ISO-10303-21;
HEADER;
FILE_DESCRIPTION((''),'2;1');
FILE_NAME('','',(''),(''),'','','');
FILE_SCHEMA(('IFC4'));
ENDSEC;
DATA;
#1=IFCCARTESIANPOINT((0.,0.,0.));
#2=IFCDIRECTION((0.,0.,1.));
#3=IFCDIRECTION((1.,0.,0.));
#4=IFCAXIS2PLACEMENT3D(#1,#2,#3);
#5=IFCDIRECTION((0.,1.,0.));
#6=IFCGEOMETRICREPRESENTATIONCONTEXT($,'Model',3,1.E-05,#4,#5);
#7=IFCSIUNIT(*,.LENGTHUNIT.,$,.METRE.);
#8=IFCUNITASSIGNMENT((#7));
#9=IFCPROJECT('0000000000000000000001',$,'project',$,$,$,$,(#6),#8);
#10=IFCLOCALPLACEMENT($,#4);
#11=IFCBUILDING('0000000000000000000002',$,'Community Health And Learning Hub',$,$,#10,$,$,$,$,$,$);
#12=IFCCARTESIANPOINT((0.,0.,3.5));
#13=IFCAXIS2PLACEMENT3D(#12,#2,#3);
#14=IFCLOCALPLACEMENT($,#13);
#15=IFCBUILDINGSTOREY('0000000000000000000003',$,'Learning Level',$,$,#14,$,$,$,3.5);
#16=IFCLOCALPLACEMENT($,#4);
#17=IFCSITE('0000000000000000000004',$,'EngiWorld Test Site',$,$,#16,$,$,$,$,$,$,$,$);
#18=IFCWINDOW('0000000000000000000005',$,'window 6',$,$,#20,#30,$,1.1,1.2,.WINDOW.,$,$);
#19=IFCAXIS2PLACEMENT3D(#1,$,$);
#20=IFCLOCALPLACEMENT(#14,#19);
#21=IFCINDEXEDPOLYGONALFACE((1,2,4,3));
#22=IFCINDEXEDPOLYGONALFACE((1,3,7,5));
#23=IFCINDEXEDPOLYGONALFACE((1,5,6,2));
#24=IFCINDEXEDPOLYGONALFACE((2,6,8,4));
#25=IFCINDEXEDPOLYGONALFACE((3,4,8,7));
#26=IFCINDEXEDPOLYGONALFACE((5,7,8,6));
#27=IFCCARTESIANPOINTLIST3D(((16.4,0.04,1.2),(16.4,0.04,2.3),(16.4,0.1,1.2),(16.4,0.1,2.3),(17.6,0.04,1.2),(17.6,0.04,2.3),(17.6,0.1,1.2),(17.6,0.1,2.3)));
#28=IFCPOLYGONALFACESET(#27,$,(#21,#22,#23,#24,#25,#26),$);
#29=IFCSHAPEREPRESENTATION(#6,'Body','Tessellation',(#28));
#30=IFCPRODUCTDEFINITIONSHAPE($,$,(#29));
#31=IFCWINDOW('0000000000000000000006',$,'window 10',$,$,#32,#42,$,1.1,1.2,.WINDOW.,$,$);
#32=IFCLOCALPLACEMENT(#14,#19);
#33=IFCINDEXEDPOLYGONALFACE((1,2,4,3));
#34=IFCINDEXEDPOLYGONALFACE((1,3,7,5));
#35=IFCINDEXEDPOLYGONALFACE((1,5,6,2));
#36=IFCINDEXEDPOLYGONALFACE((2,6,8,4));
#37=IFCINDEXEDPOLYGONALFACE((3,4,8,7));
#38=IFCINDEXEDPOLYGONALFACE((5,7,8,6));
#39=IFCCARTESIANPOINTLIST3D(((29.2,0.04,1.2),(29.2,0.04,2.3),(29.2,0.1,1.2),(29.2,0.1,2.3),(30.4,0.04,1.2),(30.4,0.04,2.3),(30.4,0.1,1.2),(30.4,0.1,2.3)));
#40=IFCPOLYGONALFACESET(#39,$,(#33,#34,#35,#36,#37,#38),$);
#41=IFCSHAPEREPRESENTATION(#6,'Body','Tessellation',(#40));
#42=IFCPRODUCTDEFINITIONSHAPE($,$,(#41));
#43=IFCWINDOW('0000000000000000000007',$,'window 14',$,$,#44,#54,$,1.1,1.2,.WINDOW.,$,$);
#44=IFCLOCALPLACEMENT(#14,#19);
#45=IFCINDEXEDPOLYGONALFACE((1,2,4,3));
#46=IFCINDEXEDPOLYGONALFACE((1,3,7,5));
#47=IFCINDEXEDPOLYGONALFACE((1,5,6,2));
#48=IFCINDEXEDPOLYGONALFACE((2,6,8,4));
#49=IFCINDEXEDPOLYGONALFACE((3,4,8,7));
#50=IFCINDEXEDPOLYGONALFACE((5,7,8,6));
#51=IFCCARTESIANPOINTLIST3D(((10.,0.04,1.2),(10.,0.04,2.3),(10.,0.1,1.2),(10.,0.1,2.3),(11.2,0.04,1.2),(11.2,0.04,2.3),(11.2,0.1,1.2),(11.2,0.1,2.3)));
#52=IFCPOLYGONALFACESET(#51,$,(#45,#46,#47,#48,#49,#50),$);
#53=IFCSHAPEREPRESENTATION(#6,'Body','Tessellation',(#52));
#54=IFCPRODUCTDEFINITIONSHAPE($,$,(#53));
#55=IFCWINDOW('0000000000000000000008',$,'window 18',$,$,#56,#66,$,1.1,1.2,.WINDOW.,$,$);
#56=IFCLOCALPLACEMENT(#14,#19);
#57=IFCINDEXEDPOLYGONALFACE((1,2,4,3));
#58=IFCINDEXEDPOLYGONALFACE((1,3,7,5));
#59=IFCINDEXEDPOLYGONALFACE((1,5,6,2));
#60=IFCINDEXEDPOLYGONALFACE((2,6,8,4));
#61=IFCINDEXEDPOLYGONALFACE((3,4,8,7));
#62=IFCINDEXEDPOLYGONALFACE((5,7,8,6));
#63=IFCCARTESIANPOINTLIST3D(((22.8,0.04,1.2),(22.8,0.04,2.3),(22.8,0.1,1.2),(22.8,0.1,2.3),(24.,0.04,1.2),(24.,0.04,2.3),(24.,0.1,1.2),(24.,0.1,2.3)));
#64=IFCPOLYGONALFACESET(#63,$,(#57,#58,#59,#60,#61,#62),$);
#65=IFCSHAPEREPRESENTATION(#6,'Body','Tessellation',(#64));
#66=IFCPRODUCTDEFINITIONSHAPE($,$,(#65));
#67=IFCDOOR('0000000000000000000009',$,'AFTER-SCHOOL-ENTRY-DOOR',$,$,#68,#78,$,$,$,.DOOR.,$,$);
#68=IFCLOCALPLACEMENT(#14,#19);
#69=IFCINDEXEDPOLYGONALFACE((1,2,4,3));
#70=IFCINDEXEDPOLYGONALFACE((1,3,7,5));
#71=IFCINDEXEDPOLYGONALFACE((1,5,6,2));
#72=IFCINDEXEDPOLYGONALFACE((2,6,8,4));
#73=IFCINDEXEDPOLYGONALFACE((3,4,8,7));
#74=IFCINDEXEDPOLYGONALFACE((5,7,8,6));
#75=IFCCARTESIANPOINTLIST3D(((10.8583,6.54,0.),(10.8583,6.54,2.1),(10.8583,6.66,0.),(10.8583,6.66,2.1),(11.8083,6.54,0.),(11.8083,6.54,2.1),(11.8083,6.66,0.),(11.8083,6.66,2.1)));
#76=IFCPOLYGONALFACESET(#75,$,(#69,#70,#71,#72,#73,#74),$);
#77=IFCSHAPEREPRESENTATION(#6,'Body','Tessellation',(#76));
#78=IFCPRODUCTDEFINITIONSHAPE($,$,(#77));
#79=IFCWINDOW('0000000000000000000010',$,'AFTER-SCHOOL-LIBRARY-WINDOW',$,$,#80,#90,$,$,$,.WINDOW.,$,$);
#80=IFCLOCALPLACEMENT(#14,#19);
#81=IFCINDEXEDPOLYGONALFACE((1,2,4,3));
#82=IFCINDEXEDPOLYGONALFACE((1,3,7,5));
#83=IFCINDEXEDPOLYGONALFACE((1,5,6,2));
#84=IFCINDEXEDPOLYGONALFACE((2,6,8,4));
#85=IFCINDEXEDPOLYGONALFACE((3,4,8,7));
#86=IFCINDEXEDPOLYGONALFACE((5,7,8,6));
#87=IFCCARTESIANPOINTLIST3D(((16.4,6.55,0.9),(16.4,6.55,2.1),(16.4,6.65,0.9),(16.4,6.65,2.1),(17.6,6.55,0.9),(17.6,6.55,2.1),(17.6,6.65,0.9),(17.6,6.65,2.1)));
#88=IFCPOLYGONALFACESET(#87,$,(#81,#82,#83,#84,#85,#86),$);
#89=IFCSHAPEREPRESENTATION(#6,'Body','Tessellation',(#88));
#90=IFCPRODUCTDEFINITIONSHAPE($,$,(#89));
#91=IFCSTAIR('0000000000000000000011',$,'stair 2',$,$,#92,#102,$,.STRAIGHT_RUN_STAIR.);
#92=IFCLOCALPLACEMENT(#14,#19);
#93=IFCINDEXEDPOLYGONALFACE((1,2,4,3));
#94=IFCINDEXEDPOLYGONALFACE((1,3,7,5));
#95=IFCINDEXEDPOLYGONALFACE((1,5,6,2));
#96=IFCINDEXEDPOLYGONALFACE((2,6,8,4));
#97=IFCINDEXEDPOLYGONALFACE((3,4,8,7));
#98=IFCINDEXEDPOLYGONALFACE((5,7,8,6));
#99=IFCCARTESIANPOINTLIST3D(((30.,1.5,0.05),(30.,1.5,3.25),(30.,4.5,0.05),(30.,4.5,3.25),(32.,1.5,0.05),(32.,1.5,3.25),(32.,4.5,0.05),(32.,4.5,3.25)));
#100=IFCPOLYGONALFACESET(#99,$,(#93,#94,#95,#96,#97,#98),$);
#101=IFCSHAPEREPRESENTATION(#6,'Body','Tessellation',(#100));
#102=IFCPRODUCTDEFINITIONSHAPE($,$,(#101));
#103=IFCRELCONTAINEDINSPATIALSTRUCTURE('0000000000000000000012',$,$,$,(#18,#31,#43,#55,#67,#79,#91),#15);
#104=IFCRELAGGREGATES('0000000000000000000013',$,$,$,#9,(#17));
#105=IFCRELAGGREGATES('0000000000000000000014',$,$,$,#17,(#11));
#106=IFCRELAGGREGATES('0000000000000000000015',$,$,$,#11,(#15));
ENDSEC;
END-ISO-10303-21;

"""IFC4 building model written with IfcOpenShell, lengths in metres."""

from ifc_helpers import new_model, si_unit, direction, frame, origin, origin_with_axes, origin_2d, origin_2d_with_axis, place, context, project, spatial, rectangle, extrude, element, save


model = new_model("IFC4")

# Units and contexts
model_context = context("Model", 3, precision=1e-05, world=origin_with_axes(), true_north=direction((0.0, 1.0, 0.0)))
ifc_project = project(units=[si_unit("LENGTHUNIT", "METRE")], contexts=[model_context])

# Site, building, storey
site_placement = place(None, origin_with_axes())
site = spatial("IfcSite", under=ifc_project, at=site_placement, Name="EngiWorld Test Site")
building_placement = place(None, origin_with_axes())
building = spatial("IfcBuilding", under=site, at=building_placement, Name="Community Health And Learning Hub")
storey_placement = place(None, frame((0.0, 0.0, 3.5), z_axis=(0.0, 0.0, 1.0), x_axis=(1.0, 0.0, 0.0)))
storey = spatial("IfcBuildingStorey", under=building, at=storey_placement, Name="Learning Level", Elevation=3.5)

# Windows
for number, where, z_axis, x_axis, name in (
    (1, (17.0, 0.07, 4.7), (0.0, 0.0, 1.0), (1.0, 0.0, 0.0), "window 6"),
    (2, (29.8, 0.07, 4.7), (0.0, 0.0, 1.0), (1.0, 0.0, 0.0), "window 10"),
    (3, (10.6, 0.07, 4.7), (0.0, 0.0, 1.0), (1.0, 0.0, 0.0), "window 14"),
    (4, (23.4, 0.07, 4.7), (0.0, 0.0, 1.0), (1.0, 0.0, 0.0), "window 18"),
):
    element("IfcWindow", number, at=place(None, frame(where, z_axis=z_axis, x_axis=x_axis)), inside=storey, Name=name, OverallHeight=1.1, OverallWidth=1.2, PredefinedType="WINDOW", context=model_context, shape_type="SweptSolid", body=[
        extrude(rectangle(XDim=1.2, YDim=0.06, at=origin_2d_with_axis()), origin_with_axes(), (0.0, 0.0, 1.0), 1.1),
    ])

# Door
door_placement = place(None, frame((11.3333, 6.6, 3.5)))
element("IfcDoor", 5, at=door_placement, inside=storey, Name="AFTER-SCHOOL-ENTRY-DOOR", PredefinedType="DOOR", context=model_context, shape_type="SweptSolid", body=[
    extrude(rectangle(XDim=0.95, YDim=0.12, at=origin_2d()), origin(), (0.0, 0.0, 1.0), 2.1),
])

# Window
window_placement = place(None, frame((17.0, 6.6, 4.4)))
element("IfcWindow", 6, at=window_placement, inside=storey, Name="AFTER-SCHOOL-LIBRARY-WINDOW", PredefinedType="WINDOW", context=model_context, shape_type="SweptSolid", body=[
    extrude(rectangle(XDim=1.2, YDim=0.1, at=origin_2d()), origin(), (0.0, 0.0, 1.0), 1.2),
])

# Stair
stair_placement = place(None, frame((31.0, 3.0, 3.55), z_axis=(0.0, 0.0, 1.0), x_axis=(1.0, 0.0, 0.0)))
element("IfcStair", 7, at=stair_placement, inside=storey, Name="stair 2", PredefinedType="STRAIGHT_RUN_STAIR", context=model_context, shape_type="SweptSolid", body=[
    extrude(rectangle(XDim=2.0, YDim=3.0, at=origin_2d_with_axis()), origin_with_axes(), (0.0, 0.0, 1.0), 3.2),
])

save(model, "model.ifc")
